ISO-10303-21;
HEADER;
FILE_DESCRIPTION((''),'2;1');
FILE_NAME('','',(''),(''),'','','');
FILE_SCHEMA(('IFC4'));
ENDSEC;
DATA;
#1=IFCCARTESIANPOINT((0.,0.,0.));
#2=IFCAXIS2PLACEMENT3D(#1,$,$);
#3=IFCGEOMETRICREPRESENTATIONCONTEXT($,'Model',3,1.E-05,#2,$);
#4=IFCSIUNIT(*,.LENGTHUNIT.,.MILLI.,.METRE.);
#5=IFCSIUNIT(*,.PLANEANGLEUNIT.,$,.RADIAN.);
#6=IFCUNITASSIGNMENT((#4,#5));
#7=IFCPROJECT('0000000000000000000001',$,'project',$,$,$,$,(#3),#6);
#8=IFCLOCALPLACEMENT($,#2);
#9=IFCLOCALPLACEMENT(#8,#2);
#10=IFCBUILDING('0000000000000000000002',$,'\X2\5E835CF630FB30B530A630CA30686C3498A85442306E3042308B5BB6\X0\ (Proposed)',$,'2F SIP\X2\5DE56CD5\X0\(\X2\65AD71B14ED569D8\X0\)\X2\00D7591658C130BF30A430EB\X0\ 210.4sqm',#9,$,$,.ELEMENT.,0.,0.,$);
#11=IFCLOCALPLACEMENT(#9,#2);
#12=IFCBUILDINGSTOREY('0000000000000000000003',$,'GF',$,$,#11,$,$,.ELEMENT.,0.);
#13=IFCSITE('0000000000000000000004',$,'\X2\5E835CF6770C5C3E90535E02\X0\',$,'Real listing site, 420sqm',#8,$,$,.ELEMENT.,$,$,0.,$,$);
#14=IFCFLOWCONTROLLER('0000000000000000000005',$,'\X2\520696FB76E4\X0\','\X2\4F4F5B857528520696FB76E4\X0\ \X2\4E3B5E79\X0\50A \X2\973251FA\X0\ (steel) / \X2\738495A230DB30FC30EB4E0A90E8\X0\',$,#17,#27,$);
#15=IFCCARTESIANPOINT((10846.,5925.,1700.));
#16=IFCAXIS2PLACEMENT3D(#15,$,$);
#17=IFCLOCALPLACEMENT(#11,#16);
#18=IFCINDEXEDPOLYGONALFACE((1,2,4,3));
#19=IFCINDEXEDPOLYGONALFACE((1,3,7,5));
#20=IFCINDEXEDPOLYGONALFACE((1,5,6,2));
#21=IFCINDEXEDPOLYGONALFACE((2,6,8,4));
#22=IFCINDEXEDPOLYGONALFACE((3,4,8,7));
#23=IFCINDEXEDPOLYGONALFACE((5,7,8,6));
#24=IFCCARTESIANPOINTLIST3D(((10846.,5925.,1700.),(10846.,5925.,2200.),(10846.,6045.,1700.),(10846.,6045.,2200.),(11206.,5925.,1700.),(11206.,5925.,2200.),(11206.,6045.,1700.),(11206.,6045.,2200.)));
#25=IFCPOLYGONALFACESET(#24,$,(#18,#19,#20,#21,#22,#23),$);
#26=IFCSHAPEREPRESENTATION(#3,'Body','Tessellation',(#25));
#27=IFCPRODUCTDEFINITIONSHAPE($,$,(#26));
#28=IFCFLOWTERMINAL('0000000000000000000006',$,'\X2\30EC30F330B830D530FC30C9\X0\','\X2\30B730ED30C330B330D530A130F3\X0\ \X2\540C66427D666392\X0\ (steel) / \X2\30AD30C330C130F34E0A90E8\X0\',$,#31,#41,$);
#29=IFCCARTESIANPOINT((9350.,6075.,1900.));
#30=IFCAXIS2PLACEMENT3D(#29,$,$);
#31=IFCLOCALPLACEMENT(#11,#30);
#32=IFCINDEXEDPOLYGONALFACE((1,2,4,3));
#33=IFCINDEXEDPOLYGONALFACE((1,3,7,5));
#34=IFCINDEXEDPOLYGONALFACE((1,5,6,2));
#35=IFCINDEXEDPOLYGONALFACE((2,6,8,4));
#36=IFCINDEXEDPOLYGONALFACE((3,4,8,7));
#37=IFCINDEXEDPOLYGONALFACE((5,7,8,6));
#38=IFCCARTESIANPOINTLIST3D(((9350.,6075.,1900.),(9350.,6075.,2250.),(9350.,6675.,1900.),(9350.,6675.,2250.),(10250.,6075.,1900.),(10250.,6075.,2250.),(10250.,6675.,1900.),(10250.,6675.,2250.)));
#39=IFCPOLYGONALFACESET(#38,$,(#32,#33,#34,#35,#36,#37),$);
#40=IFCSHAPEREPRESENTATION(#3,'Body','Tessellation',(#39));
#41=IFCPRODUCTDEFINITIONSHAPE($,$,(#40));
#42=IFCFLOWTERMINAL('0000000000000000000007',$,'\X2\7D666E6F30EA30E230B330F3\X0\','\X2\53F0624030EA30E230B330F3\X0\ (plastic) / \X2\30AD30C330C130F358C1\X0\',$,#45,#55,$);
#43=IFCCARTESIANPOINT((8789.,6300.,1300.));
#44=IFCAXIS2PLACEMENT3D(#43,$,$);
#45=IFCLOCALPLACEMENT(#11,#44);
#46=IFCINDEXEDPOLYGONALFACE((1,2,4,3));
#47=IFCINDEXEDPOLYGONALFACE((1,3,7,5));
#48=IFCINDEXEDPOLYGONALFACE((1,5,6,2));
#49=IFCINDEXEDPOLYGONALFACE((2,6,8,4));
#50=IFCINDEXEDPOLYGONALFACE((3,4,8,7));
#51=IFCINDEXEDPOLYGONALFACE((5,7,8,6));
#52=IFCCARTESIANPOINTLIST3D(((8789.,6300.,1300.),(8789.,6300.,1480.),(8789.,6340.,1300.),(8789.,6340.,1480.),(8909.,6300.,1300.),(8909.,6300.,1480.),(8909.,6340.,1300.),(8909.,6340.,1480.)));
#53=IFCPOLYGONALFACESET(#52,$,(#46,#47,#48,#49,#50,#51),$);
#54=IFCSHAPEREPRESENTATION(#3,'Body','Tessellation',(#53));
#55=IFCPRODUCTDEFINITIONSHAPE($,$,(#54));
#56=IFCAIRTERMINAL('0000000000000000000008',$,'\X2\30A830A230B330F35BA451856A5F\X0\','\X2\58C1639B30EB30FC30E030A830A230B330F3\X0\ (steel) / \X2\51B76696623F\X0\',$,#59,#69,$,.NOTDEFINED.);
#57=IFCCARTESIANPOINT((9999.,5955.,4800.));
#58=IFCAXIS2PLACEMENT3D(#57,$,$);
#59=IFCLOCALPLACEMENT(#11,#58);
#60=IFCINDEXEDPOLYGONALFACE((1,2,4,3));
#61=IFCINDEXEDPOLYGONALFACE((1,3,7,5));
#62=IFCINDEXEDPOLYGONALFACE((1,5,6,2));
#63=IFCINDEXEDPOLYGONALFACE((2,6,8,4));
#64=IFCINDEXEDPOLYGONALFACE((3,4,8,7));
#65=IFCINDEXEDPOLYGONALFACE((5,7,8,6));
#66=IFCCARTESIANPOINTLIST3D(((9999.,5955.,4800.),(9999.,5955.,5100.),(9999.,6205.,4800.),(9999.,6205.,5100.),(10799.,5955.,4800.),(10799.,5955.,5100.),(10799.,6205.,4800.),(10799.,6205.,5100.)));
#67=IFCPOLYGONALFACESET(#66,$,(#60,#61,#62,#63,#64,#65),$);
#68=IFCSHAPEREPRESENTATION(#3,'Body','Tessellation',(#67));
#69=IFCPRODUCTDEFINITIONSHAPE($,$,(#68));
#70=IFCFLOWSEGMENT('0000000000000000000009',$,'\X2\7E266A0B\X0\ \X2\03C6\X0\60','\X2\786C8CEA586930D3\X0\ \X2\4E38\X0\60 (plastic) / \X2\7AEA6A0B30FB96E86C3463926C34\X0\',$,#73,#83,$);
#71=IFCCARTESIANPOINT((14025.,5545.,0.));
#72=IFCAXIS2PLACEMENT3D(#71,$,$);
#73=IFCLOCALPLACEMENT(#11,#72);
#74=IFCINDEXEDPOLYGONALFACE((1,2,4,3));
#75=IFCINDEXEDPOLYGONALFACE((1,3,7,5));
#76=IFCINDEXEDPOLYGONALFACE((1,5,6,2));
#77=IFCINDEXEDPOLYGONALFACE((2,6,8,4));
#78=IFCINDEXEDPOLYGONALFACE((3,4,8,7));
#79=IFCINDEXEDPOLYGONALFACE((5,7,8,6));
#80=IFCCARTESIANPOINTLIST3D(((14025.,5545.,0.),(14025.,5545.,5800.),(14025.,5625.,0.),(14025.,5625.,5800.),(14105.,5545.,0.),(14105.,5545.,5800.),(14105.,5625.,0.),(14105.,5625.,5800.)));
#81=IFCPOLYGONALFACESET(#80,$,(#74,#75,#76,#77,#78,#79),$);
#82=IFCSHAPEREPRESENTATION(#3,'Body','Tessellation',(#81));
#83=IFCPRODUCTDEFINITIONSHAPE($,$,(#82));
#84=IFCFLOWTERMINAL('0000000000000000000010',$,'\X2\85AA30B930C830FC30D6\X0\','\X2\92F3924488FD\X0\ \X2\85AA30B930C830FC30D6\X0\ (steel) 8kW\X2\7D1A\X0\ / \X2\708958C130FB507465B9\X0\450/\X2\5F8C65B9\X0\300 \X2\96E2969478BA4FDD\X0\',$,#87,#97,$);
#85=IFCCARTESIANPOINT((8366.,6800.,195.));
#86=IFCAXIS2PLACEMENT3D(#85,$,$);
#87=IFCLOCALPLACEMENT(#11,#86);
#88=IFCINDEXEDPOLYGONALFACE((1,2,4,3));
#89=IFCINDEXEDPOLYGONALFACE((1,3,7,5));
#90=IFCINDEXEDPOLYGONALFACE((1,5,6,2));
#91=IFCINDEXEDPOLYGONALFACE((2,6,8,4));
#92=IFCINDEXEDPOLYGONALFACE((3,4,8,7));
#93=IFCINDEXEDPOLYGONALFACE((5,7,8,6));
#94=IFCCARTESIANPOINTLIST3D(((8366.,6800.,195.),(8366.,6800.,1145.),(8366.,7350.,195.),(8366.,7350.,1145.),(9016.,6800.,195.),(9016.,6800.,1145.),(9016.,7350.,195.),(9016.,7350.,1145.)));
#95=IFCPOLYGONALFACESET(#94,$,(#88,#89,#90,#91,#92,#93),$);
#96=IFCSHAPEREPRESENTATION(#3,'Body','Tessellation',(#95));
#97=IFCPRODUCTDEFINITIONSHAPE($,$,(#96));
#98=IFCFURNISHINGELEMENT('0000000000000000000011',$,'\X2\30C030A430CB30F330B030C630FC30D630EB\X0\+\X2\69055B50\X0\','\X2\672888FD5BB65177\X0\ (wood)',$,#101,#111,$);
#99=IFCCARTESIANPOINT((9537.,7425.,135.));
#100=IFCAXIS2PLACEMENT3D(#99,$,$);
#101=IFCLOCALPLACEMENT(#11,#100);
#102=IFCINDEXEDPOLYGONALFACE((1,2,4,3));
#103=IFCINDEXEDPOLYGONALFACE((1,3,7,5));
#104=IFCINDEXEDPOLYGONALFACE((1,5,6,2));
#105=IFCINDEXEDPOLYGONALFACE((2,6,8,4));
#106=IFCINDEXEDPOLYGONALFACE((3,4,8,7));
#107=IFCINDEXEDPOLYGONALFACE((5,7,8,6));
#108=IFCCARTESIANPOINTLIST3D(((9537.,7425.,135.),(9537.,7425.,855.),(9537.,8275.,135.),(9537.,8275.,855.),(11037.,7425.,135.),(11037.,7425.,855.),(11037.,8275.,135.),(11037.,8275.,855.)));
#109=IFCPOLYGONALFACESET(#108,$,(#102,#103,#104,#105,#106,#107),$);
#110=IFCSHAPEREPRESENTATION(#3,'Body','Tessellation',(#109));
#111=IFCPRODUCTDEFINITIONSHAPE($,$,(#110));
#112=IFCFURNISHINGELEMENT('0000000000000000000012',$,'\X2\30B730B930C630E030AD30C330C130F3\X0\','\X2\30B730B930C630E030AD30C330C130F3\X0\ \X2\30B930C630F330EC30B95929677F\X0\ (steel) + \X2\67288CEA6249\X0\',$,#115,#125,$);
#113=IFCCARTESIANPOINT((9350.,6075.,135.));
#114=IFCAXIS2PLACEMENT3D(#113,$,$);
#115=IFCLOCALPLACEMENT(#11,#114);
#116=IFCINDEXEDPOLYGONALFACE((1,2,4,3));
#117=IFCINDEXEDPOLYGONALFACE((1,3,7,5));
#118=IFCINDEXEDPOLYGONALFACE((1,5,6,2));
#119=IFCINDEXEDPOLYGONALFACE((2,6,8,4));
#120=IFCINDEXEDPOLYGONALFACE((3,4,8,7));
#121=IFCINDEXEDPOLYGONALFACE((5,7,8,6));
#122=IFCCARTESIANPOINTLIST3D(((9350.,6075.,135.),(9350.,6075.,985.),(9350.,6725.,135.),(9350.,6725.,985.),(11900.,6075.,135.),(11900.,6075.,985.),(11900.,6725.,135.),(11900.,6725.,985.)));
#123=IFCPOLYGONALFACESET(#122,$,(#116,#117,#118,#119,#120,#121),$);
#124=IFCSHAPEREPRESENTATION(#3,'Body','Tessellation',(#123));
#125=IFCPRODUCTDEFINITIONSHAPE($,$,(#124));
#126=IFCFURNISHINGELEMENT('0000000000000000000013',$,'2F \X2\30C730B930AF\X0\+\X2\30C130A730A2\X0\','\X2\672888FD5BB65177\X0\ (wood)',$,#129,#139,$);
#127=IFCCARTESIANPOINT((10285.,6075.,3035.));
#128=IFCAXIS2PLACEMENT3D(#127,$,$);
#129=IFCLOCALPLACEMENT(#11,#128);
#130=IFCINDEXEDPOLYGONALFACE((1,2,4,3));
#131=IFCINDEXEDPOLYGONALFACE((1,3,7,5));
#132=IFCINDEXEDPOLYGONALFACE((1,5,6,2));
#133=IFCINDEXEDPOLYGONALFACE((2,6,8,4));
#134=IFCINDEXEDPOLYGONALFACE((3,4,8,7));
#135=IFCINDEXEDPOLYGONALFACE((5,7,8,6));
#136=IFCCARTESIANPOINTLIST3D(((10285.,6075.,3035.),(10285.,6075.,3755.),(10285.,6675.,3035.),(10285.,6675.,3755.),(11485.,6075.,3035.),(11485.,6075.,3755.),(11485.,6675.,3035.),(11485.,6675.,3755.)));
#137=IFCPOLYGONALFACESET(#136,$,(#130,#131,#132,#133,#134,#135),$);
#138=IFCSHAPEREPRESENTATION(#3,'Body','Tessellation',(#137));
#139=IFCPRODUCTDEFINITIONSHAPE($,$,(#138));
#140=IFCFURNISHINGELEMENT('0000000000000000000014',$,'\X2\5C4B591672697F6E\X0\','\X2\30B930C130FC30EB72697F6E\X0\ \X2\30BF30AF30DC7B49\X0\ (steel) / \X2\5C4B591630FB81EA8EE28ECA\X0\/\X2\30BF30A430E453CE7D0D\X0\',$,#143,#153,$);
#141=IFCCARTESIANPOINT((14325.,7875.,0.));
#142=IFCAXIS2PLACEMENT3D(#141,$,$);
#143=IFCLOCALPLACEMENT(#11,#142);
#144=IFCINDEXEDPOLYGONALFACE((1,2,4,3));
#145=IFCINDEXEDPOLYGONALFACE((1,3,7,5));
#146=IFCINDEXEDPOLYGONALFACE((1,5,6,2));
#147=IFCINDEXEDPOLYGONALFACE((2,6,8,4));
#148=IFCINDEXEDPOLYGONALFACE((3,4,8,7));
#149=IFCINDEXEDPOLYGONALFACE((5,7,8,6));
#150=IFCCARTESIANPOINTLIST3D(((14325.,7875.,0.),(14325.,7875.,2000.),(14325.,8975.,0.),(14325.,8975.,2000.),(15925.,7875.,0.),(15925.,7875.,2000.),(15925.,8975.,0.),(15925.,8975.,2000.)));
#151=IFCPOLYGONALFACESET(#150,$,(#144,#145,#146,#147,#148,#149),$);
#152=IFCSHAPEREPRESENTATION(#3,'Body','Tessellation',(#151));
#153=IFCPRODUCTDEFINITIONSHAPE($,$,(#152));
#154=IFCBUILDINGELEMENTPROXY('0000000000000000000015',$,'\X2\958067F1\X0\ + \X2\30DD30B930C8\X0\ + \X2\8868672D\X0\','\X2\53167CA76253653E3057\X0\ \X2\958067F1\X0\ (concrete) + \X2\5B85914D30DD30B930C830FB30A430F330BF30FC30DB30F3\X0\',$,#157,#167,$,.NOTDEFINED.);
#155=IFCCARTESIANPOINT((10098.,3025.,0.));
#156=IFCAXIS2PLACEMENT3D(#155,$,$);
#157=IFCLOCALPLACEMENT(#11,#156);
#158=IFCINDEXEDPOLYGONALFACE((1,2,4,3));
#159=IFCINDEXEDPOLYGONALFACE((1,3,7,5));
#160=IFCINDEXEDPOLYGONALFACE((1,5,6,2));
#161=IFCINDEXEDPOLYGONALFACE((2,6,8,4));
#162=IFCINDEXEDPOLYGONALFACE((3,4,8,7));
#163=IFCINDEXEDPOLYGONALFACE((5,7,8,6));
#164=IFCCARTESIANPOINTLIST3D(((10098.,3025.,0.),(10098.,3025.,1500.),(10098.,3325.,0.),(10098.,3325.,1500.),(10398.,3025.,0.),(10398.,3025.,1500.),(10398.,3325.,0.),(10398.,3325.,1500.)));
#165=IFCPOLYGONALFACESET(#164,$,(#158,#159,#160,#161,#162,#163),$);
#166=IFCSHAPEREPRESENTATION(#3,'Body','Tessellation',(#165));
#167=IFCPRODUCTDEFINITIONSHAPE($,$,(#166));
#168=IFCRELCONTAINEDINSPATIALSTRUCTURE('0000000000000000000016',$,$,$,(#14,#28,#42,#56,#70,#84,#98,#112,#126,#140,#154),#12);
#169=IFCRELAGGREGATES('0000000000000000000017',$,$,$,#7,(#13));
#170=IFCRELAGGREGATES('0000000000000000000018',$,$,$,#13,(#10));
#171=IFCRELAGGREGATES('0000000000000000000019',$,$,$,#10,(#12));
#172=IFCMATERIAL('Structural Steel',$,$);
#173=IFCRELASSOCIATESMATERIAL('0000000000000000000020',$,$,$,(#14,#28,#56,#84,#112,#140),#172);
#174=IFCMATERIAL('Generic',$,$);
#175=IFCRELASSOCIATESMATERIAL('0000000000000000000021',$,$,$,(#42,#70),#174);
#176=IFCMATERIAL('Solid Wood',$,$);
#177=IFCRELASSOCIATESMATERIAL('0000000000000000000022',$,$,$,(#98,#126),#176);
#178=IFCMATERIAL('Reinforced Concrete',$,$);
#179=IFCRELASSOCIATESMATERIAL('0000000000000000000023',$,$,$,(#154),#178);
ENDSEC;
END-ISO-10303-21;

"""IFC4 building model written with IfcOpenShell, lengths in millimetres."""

from ifc_helpers import new_model, si_unit, frame, frame_2d, origin, place, context, project, spatial, rectangle, extrude, material, element, save


model = new_model("IFC4")

# Units and contexts
model_context = context("Model", 3, precision=1e-05, world=origin())
ifc_project = project(units=[si_unit("LENGTHUNIT", "METRE", prefix="MILLI"), si_unit("PLANEANGLEUNIT", "RADIAN")], contexts=[model_context])

# Site, building, storey
site_placement = place(None, origin())
site = spatial("IfcSite", under=ifc_project, at=site_placement, Name="広島県尾道市", ObjectType="Real listing site, 420sqm", CompositionType="ELEMENT", RefElevation=0.0)
building_placement = place(site_placement, origin())
building = spatial("IfcBuilding", under=site, at=building_placement, Name="広島・サウナと水風呂のある家 (Proposed)", ObjectType="2F SIP工法(断熱仕様)×外壁タイル 210.4sqm", CompositionType="ELEMENT", ElevationOfRefHeight=0.0, ElevationOfTerrain=0.0)
storey_placement = place(building_placement, origin())
storey = spatial("IfcBuildingStorey", under=building, at=storey_placement, Name="GF", CompositionType="ELEMENT", Elevation=0.0)

# Shared definitions
ifc_material_1 = material(Name="Solid Wood")

# Shared definitions
ifc_material_2 = material(Name="Structural Steel")

# Shared definitions
ifc_material_3 = material(Name="Reinforced Concrete")

# Flow controller
flow_controller_placement = place(storey_placement, frame((10846.0, 5925.0, 1700.0)))
element("IfcFlowController", 1, at=flow_controller_placement, inside=storey, material=ifc_material_2, Name="分電盤", Description="住宅用分電盤 主幹50A 露出 (steel) / 玄関ホール上部", context=model_context, shape_type="SweptSolid", body=[
    extrude(rectangle(XDim=360.0, YDim=120.0, at=frame_2d((180.0, 60.0))), frame((10846.0, 5925.0, 1700.0)), (0.0, 0.0, 1.0), 500.0),
])

# Flow terminals
flow_terminal_1_placement = place(storey_placement, frame((9350.0, 6075.0, 1900.0)))
element("IfcFlowTerminal", 2, at=flow_terminal_1_placement, inside=storey, material=ifc_material_2, Name="レンジフード", Description="シロッコファン 同時給排 (steel) / キッチン上部", context=model_context, shape_type="SweptSolid", body=[
    extrude(rectangle(XDim=900.0, YDim=600.0, at=frame_2d((450.0, 300.0))), frame((9350.0, 6075.0, 1900.0)), (0.0, 0.0, 1.0), 350.0),
])
ifc_material_4 = material(Name="Generic")
flow_terminal_2_placement = place(storey_placement, frame((8789.0, 6300.0, 1300.0)))
element("IfcFlowTerminal", 3, at=flow_terminal_2_placement, inside=storey, material=ifc_material_4, Name="給湯リモコン", Description="台所リモコン (plastic) / キッチン壁", context=model_context, shape_type="SweptSolid", body=[
    extrude(rectangle(XDim=120.0, YDim=40.0, at=frame_2d((60.0, 20.0))), frame((8789.0, 6300.0, 1300.0)), (0.0, 0.0, 1.0), 180.0),
])

# Air terminal
air_terminal_placement = place(storey_placement, frame((9999.0, 5955.0, 4800.0)))
element("IfcAirTerminal", 4, at=air_terminal_placement, inside=storey, material=ifc_material_2, Name="エアコン室内機", Description="壁掛ルームエアコン (steel) / 冷暖房", PredefinedType="NOTDEFINED", context=model_context, shape_type="SweptSolid", body=[
    extrude(rectangle(XDim=800.0, YDim=250.0, at=frame_2d((400.0, 125.0))), frame((9999.0, 5955.0, 4800.0)), (0.0, 0.0, 1.0), 300.0),
])

# Flow segment
flow_segment_placement = place(storey_placement, frame((14025.0, 5545.0, 0.0)))
element("IfcFlowSegment", 5, at=flow_segment_placement, inside=storey, material=ifc_material_4, Name="縦樋 φ60", Description="硬質塩ビ 丸60 (plastic) / 竪樋・雨水排水", context=model_context, shape_type="SweptSolid", body=[
    extrude(rectangle(XDim=80.0, YDim=80.0, at=frame_2d((40.0, 40.0))), frame((14025.0, 5545.0, 0.0)), (0.0, 0.0, 1.0), 5800.0),
])

# Flow terminal
flow_terminal_3_placement = place(storey_placement, frame((8366.0, 6800.0, 195.0)))
element("IfcFlowTerminal", 6, at=flow_terminal_3_placement, inside=storey, material=ifc_material_2, Name="薪ストーブ", Description="鋳鉄製 薪ストーブ (steel) 8kW級 / 炉壁・側方450/後方300 離隔確保", context=model_context, shape_type="SweptSolid", body=[
    extrude(rectangle(XDim=650.0, YDim=550.0, at=frame_2d((325.0, 275.0))), frame((8366.0, 6800.0, 195.0)), (0.0, 0.0, 1.0), 950.0),
])

# Furnishing elements
furnishing_1_placement = place(storey_placement, frame((9537.0, 7425.0, 135.0)))
element("IfcFurnishingElement", 7, at=furnishing_1_placement, inside=storey, material=ifc_material_1, Name="ダイニングテーブル+椅子", Description="木製家具 (wood)", context=model_context, shape_type="SweptSolid", body=[
    extrude(rectangle(XDim=1500.0, YDim=850.0, at=frame_2d((750.0, 425.0))), frame((9537.0, 7425.0, 135.0)), (0.0, 0.0, 1.0), 720.0),
])
furnishing_2_placement = place(storey_placement, frame((9350.0, 6075.0, 135.0)))
element("IfcFurnishingElement", 8, at=furnishing_2_placement, inside=storey, material=ifc_material_2, Name="システムキッチン", Description="システムキッチン ステンレス天板 (steel) + 木質扉", context=model_context, shape_type="SweptSolid", body=[
    extrude(rectangle(XDim=2550.0, YDim=650.0, at=frame_2d((1275.0, 325.0))), frame((9350.0, 6075.0, 135.0)), (0.0, 0.0, 1.0), 850.0),
])
furnishing_3_placement = place(storey_placement, frame((10285.0, 6075.0, 3035.0)))
element("IfcFurnishingElement", 9, at=furnishing_3_placement, inside=storey, material=ifc_material_1, Name="2F デスク+チェア", Description="木製家具 (wood)", context=model_context, shape_type="SweptSolid", body=[
    extrude(rectangle(XDim=1200.0, YDim=600.0, at=frame_2d((600.0, 300.0))), frame((10285.0, 6075.0, 3035.0)), (0.0, 0.0, 1.0), 720.0),
])
furnishing_4_placement = place(storey_placement, frame((14325.0, 7875.0, 0.0)))
element("IfcFurnishingElement", 10, at=furnishing_4_placement, inside=storey, material=ifc_material_2, Name="屋外物置", Description="スチール物置 タクボ等 (steel) / 屋外・自転車/タイヤ収納", context=model_context, shape_type="SweptSolid", body=[
    extrude(rectangle(XDim=1600.0, YDim=1100.0, at=frame_2d((800.0, 550.0))), frame((14325.0, 7875.0, 0.0)), (0.0, 0.0, 1.0), 2000.0),
])

# Building element proxy
proxy_placement = place(storey_placement, frame((10098.0, 3025.0, 0.0)))
element("IfcBuildingElementProxy", 11, at=proxy_placement, inside=storey, material=ifc_material_3, Name="門柱 + ポスト + 表札", Description="化粧打放し 門柱 (concrete) + 宅配ポスト・インターホン", PredefinedType="NOTDEFINED", context=model_context, shape_type="SweptSolid", body=[
    extrude(rectangle(XDim=300.0, YDim=300.0, at=frame_2d((150.0, 150.0))), frame((10098.0, 3025.0, 0.0)), (0.0, 0.0, 1.0), 1500.0),
])

save(model, "model.ifc")
